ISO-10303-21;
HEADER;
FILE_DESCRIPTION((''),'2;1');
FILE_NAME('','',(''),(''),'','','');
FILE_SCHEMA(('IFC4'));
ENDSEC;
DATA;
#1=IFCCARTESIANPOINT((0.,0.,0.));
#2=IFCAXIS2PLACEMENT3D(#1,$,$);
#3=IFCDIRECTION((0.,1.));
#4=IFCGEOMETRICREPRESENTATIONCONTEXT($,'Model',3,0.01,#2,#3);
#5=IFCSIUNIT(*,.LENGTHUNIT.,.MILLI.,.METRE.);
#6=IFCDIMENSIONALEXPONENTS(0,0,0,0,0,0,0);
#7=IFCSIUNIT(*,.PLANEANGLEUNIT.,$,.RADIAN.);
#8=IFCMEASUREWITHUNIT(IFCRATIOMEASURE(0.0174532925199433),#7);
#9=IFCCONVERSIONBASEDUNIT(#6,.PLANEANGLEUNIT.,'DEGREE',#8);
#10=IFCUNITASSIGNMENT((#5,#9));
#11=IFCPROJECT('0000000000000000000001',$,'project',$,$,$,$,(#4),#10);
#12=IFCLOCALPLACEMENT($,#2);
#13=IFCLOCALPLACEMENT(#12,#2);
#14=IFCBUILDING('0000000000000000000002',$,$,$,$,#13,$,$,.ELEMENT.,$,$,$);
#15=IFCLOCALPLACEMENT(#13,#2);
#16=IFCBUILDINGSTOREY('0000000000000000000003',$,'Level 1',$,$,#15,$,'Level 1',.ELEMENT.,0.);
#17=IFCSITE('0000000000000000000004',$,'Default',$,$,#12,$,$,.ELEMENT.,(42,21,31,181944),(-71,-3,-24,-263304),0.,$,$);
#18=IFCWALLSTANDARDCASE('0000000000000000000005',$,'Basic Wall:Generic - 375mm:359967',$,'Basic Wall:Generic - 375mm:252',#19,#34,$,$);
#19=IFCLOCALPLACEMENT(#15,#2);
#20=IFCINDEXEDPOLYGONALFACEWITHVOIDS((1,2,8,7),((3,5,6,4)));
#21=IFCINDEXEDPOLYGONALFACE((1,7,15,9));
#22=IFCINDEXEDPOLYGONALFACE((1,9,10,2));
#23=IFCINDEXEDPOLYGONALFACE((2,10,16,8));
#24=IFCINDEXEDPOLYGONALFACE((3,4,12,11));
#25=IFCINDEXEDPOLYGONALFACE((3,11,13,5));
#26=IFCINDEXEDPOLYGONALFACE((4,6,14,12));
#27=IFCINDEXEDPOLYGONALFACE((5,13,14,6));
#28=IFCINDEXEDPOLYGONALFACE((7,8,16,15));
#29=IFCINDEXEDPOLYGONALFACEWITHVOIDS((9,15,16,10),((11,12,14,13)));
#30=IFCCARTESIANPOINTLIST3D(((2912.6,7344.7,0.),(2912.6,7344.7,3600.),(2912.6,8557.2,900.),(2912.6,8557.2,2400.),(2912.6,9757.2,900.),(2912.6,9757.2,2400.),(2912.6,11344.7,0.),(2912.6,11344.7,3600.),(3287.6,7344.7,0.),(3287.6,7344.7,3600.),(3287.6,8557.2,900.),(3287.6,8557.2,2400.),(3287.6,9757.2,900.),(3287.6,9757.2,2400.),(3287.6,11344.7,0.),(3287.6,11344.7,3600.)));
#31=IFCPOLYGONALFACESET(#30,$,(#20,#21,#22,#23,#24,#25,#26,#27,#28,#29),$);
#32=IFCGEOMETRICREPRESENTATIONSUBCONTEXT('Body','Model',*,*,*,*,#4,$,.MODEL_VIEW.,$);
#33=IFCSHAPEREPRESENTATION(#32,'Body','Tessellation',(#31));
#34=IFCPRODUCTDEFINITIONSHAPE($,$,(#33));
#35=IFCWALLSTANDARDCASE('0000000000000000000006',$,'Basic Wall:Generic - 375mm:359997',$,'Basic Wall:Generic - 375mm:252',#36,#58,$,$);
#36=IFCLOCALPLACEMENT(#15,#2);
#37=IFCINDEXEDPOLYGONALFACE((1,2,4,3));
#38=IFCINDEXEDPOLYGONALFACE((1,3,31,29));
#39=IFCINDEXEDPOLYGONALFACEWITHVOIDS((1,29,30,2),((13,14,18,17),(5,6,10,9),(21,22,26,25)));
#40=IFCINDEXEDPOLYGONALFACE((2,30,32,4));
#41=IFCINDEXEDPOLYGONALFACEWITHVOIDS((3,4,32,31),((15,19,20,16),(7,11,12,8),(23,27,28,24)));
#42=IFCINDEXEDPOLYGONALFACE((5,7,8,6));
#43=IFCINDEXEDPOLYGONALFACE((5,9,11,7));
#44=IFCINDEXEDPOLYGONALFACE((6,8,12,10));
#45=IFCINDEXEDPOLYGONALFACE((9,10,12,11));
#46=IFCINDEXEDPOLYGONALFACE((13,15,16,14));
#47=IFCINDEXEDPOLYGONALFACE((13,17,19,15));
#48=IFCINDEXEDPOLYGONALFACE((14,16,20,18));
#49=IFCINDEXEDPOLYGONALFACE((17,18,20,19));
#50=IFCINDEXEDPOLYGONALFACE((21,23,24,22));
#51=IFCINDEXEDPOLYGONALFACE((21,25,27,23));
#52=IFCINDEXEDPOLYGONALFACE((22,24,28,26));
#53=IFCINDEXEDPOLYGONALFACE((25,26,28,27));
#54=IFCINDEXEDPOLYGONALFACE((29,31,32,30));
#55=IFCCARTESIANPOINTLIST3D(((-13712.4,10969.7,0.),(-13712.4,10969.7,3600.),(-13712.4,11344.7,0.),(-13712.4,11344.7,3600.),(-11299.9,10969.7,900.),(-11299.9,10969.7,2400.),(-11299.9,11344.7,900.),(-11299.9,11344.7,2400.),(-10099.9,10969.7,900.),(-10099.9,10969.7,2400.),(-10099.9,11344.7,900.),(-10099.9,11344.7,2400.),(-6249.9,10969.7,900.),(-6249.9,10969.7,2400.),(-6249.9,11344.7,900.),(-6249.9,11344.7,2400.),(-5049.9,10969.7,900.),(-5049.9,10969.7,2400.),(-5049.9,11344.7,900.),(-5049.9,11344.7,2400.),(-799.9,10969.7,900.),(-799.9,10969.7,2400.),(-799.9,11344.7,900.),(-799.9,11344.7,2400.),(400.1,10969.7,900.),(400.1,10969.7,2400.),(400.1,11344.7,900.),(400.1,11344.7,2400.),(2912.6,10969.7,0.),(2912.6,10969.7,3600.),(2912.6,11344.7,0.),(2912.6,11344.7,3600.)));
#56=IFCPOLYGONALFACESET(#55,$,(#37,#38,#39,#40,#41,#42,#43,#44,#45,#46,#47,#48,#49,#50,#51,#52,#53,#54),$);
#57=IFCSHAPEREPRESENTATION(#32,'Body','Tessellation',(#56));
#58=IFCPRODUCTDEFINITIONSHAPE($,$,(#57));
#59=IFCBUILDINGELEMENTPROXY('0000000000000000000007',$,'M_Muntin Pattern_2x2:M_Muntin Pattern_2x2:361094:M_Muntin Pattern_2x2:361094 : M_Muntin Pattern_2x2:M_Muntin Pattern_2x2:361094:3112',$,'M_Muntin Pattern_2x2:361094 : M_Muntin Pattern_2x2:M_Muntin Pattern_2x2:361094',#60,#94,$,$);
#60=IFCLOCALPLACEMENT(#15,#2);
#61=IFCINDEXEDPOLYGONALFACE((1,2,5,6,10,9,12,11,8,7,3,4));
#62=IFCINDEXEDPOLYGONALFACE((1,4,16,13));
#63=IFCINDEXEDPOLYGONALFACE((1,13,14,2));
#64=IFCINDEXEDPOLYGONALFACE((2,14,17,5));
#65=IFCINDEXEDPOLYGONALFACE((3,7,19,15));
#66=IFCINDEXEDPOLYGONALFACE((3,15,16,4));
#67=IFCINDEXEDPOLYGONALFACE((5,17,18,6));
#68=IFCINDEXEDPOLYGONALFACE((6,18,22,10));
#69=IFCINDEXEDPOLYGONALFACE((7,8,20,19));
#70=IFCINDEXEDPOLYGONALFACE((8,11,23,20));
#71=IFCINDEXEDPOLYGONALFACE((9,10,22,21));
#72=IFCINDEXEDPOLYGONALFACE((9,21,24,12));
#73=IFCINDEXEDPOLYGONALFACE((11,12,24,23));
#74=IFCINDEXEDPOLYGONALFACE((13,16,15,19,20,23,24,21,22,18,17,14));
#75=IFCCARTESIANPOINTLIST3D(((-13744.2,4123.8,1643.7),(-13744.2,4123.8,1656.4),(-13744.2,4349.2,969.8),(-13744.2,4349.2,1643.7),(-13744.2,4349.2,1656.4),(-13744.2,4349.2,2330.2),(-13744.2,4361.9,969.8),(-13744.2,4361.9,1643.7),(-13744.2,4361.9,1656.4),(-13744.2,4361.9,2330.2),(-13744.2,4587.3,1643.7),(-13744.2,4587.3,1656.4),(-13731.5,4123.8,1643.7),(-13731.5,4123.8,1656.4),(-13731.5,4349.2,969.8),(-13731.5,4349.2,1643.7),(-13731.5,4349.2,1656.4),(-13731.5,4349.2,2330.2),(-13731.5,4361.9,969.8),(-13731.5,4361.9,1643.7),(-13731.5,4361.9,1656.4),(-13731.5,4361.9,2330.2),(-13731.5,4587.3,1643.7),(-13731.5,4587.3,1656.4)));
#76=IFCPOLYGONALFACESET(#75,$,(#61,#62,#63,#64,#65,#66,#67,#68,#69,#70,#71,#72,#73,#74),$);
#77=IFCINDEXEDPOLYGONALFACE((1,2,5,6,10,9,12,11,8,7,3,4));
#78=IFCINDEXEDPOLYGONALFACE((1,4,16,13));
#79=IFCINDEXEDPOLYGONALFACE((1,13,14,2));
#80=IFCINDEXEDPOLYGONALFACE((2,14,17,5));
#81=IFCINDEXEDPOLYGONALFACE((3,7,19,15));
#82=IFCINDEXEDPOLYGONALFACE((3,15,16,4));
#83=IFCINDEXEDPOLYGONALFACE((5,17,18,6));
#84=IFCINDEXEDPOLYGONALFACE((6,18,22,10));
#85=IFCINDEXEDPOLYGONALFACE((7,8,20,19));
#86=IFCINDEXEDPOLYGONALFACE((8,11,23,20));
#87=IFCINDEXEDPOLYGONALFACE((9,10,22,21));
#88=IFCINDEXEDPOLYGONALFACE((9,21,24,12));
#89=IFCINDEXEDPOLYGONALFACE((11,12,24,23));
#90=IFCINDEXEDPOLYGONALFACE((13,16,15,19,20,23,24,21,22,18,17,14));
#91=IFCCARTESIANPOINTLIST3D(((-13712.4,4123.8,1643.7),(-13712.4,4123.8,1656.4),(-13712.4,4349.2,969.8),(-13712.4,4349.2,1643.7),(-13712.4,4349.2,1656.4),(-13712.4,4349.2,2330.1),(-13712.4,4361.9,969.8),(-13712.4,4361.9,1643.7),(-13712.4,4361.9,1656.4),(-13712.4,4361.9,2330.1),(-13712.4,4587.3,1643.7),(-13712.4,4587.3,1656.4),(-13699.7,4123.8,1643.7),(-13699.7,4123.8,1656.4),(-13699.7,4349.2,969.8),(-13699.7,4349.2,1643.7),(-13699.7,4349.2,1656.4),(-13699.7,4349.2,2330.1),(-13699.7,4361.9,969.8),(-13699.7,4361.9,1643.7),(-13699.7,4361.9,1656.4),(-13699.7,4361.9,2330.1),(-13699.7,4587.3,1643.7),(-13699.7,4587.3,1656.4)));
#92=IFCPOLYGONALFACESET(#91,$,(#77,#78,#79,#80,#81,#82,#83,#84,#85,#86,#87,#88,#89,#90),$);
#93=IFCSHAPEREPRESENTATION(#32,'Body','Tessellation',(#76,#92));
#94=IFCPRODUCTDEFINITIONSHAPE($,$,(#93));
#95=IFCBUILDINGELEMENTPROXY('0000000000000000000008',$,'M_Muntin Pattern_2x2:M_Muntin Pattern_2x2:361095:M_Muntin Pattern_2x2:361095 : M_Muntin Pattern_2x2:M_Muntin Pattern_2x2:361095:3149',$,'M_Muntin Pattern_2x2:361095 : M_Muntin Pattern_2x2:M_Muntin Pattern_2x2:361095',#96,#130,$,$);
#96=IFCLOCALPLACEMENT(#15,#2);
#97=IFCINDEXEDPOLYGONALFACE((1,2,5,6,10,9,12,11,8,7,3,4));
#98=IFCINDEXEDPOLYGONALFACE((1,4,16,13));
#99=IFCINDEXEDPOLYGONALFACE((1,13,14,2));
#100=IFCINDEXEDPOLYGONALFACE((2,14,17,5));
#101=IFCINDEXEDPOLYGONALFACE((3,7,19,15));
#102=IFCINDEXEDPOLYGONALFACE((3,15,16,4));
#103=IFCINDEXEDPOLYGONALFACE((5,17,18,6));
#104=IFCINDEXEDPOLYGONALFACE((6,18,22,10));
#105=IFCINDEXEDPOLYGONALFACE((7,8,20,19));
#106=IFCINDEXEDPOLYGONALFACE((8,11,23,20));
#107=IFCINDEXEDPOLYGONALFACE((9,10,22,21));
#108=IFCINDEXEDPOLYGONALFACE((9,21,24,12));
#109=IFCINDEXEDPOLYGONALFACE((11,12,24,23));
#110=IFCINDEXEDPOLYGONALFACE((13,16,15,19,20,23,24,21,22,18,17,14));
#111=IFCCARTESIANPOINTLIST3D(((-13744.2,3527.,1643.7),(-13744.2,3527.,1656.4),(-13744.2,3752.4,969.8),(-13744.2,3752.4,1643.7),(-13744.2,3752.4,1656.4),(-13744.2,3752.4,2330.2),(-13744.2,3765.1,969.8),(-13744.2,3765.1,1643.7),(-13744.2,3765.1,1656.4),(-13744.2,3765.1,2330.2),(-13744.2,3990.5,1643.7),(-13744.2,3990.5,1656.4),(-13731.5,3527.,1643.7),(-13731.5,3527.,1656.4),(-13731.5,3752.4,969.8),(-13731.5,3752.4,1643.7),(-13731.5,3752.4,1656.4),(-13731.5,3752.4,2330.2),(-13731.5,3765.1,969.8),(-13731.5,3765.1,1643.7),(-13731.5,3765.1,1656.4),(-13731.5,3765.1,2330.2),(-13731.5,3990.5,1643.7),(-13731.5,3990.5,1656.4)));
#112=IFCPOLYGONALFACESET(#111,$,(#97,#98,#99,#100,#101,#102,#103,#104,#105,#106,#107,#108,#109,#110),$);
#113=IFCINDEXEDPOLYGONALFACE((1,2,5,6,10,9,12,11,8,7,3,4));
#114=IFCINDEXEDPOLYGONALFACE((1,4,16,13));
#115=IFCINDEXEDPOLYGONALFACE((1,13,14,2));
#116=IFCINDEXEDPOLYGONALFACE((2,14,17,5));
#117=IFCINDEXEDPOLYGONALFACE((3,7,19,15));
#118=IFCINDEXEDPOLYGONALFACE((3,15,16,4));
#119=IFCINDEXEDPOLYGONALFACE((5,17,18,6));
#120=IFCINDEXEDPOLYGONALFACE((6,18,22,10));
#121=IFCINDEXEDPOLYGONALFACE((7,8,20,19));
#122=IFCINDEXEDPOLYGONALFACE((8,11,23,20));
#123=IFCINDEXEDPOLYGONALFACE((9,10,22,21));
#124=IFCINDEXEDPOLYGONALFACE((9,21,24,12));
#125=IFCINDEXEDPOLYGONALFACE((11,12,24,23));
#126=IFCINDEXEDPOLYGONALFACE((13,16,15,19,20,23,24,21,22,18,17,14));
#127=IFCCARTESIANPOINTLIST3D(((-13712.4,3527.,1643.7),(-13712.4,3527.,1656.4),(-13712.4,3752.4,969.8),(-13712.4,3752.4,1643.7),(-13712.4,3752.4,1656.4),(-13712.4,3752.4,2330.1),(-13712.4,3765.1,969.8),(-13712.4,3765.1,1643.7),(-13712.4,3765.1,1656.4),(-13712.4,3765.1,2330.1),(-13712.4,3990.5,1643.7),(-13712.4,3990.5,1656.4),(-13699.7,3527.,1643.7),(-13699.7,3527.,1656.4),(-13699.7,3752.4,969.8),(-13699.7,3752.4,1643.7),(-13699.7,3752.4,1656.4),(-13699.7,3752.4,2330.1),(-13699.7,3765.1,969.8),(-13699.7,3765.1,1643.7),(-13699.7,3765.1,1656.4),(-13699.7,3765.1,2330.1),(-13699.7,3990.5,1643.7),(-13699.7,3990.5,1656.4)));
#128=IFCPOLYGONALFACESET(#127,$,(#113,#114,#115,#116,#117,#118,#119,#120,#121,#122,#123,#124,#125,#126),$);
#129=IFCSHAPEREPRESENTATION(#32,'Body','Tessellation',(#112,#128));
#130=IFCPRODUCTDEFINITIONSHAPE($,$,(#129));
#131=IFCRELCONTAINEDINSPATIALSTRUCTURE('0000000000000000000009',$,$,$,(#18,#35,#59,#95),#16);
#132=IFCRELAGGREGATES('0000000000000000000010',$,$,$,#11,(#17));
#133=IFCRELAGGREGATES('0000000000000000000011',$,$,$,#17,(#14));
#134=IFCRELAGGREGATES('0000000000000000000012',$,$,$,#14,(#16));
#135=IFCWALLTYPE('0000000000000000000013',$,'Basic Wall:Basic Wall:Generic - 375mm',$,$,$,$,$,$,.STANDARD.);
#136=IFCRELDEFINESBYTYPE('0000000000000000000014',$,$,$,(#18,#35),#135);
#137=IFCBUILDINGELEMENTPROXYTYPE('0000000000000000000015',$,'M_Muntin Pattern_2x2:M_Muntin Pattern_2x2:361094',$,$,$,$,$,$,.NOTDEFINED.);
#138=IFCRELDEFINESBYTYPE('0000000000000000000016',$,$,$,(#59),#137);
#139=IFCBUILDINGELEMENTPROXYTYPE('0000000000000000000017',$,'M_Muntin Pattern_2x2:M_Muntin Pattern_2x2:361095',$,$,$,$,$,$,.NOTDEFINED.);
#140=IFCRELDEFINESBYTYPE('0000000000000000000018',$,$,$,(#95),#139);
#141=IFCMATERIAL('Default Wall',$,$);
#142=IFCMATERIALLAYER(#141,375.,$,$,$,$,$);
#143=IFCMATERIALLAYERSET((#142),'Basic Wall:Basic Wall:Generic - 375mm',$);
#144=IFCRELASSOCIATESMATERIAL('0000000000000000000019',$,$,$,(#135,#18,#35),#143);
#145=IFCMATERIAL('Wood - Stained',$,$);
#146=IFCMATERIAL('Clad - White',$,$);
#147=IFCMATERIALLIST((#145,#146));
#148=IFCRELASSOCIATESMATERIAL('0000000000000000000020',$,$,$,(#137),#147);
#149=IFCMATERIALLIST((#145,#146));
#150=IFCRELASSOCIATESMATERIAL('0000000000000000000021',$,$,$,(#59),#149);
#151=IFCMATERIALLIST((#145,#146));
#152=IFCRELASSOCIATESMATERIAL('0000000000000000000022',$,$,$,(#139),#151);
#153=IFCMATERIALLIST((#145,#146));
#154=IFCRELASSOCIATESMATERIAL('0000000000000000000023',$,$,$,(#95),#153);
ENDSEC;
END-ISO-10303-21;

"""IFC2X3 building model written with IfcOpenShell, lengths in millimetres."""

from ifc_helpers import new_model, entity, si_unit, converted_unit, direction, frame, frame_2d, origin, place, context, subcontext, project, spatial, polyline, rectangle, outline, extrude, source, transform, mapped, material, material_list, layer, layer_set, layer_usage, type_object, type_shapes, element, save


model = new_model("IFC2X3")

# Units and contexts
model_context = context("Model", 3, precision=0.01, world=origin(), true_north=direction((0.0, 1.0)))
body_context = subcontext(model_context, "Body", "Model", "MODEL_VIEW")
ifc_project = project(units=[si_unit("LENGTHUNIT", "METRE", prefix="MILLI"), converted_unit("PLANEANGLEUNIT", "DEGREE", entity("IfcRatioMeasure", 0.0174532925199433), si_unit("PLANEANGLEUNIT", "RADIAN"), dimensions=[0, 0, 0, 0, 0, 0, 0])], contexts=[model_context])

# Site, building, storey
site_placement = place(None, origin())
site = spatial("IfcSite", under=ifc_project, at=site_placement, Name="Default", CompositionType="ELEMENT", RefLatitude=(42, 21, 31, 181944), RefLongitude=(-71, -3, -24, -263304), RefElevation=0.0)
building_placement = place(site_placement, origin())
building = spatial("IfcBuilding", under=site, at=building_placement, CompositionType="ELEMENT")
storey_placement = place(building_placement, origin())
storey = spatial("IfcBuildingStorey", under=building, at=storey_placement, Name="Level 1", LongName="Level 1", CompositionType="ELEMENT", Elevation=0.0)

# Wall, opening
ifc_material_1 = material(Name="Default Wall")
ifc_layer = layer(ifc_material_1, 375.0)
ifc_layer_set = layer_set([ifc_layer], Name="Basic Wall:Basic Wall:Generic - 375mm")
ifc_layer_usage_1 = layer_usage(ifc_layer_set, "AXIS2", "NEGATIVE", 187.5)
wall_type = type_object("IfcWallType", Name="Basic Wall:Basic Wall:Generic - 375mm", PredefinedType="STANDARD", material=ifc_layer_set)
wall_1_placement = place(storey_placement, frame((3100.1, 7344.7, 0.0), z_axis=(0.0, 0.0, 1.0), x_axis=(0.0, 1.0, 0.0)))
wall_1 = element("IfcWallStandardCase", 1, at=wall_1_placement, inside=storey, type_object=wall_type, material=ifc_layer_usage_1, Name="Basic Wall:Generic - 375mm:359967", ObjectType="Basic Wall:Generic - 375mm:252", context=body_context, shape_type="SweptSolid", body=[
    extrude(rectangle(XDim=4000.0, YDim=375.0, at=frame_2d((2000.0, 0.0), x_axis=(-1.0, 0.0))), origin(), (0.0, 0.0, 1.0), 3600.0),
])
opening_1_placement = place(wall_1_placement, frame((-7344.7, 3100.1, 0.0), z_axis=(0.0, 0.0, 1.0), x_axis=(0.0, -1.0, 0.0)))
element("IfcOpeningElement", 2, at=opening_1_placement, cuts=wall_1, ObjectType="Opening", context=body_context, shape_type="SweptSolid", body=[
    extrude(rectangle(XDim=1500.0, YDim=1200.0, at=frame_2d((0.0, 0.0), x_axis=(0.0, 1.0))), frame((3291.3, 9157.2, 1650.0), z_axis=(-1.0, 0.0, 0.0), x_axis=(0.0, -1.0, 0.0)), (0.0, 0.0, 1.0), 382.5),
])

# Wall, openings
ifc_layer_usage_2 = layer_usage(ifc_layer_set, "AXIS2", "NEGATIVE", 187.5)
wall_2_placement = place(storey_placement, frame((2912.6, 11157.2, 0.0), z_axis=(0.0, 0.0, 1.0), x_axis=(-1.0, 0.0, 0.0)))
wall_2 = element("IfcWallStandardCase", 3, at=wall_2_placement, inside=storey, type_object=wall_type, material=ifc_layer_usage_2, Name="Basic Wall:Generic - 375mm:359997", ObjectType="Basic Wall:Generic - 375mm:252", context=body_context, shape_type="SweptSolid", body=[
    extrude(rectangle(XDim=16625.0, YDim=375.0, at=frame_2d((8312.5, 0.0), x_axis=(-1.0, 0.0))), origin(), (0.0, 0.0, 1.0), 3600.0),
])
opening_2_placement = place(wall_2_placement, frame((2912.6, 11157.2, 0.0), z_axis=(0.0, 0.0, 1.0), x_axis=(-1.0, 0.0, 0.0)))
element("IfcOpeningElement", 4, at=opening_2_placement, cuts=wall_2, ObjectType="Opening", context=body_context, shape_type="SweptSolid", body=[
    extrude(rectangle(XDim=1500.0, YDim=1200.0, at=frame_2d((0.0, 0.0), x_axis=(0.0, 1.0))), frame((-5649.9, 11348.4, 1650.0), z_axis=(0.0, -1.0, 0.0), x_axis=(1.0, 0.0, 0.0)), (0.0, 0.0, 1.0), 382.5),
])
opening_3_placement = place(wall_2_placement, frame((2912.6, 11157.2, 0.0), z_axis=(0.0, 0.0, 1.0), x_axis=(-1.0, 0.0, 0.0)))
element("IfcOpeningElement", 5, at=opening_3_placement, cuts=wall_2, ObjectType="Opening", context=body_context, shape_type="SweptSolid", body=[
    extrude(rectangle(XDim=1500.0, YDim=1200.0, at=frame_2d((0.0, 0.0), x_axis=(0.0, 1.0))), frame((-199.9, 11348.4, 1650.0), z_axis=(0.0, -1.0, 0.0), x_axis=(1.0, 0.0, 0.0)), (0.0, 0.0, 1.0), 382.5),
])
opening_4_placement = place(wall_2_placement, frame((2912.6, 11157.2, 0.0), z_axis=(0.0, 0.0, 1.0), x_axis=(-1.0, 0.0, 0.0)))
element("IfcOpeningElement", 6, at=opening_4_placement, cuts=wall_2, ObjectType="Opening", context=body_context, shape_type="SweptSolid", body=[
    extrude(rectangle(XDim=1500.0, YDim=1200.0, at=frame_2d((0.0, 0.0), x_axis=(0.0, 1.0))), frame((-10699.9, 11348.4, 1650.0), z_axis=(0.0, -1.0, 0.0), x_axis=(1.0, 0.0, 0.0)), (0.0, 0.0, 1.0), 382.5),
])

# Building element proxies
ifc_material_2 = material(Name="Wood - Stained")
ifc_material_3 = material(Name="Clad - White")
ifc_material_list_1 = material_list([ifc_material_2, ifc_material_3])
ifc_material_list_2 = material_list([ifc_material_2, ifc_material_3])
building_element_proxy_type_1 = type_object("IfcBuildingElementProxyType", Name="M_Muntin Pattern_2x2:M_Muntin Pattern_2x2:361094", PredefinedType="NOTDEFINED", material=ifc_material_list_2)
shared_shape_1 = source(origin(), body_context, "Body", "SweptSolid", [
    extrude(outline(polyline([(-6.4, -680.2), (6.3, -680.2), (6.3, -6.4), (231.7, -6.4), (231.7, 6.3), (6.3, 6.3), (6.3, 680.2), (-6.4, 680.2), (-6.4, 6.3), (-231.7, 6.3), (-231.7, -6.4), (-6.4, -6.4), (-6.4, -680.2)])), frame((-13744.2, 4355.6, 1650.0), z_axis=(1.0, 0.0, 0.0), x_axis=(0.0, -1.0, 0.0)), (0.0, 0.0, 1.0), 12.7),
    extrude(outline(polyline([(-6.4, -680.1), (6.3, -680.1), (6.3, -6.4), (231.7, -6.4), (231.7, 6.3), (6.3, 6.3), (6.3, 680.2), (-6.4, 680.2), (-6.4, 6.3), (-231.7, 6.3), (-231.7, -6.4), (-6.4, -6.4), (-6.4, -680.1)])), frame((-13712.4, 4355.6, 1650.0), z_axis=(1.0, 0.0, 0.0), x_axis=(0.0, -1.0, 0.0)), (0.0, 0.0, 1.0), 12.7),
])
type_shapes(building_element_proxy_type_1, [shared_shape_1])
proxy_1_placement = place(storey_placement, origin())
element("IfcBuildingElementProxy", 7, at=proxy_1_placement, inside=storey, type_object=building_element_proxy_type_1, material=ifc_material_list_1, Name="M_Muntin Pattern_2x2:M_Muntin Pattern_2x2:361094:M_Muntin Pattern_2x2:361094 : M_Muntin Pattern_2x2:M_Muntin Pattern_2x2:361094:3112", ObjectType="M_Muntin Pattern_2x2:361094 : M_Muntin Pattern_2x2:M_Muntin Pattern_2x2:361094", context=body_context, shape_type="MappedRepresentation", body=[
    mapped(shared_shape_1, transform((0.0, 0.0, 0.0), scale=1.0)),
])
ifc_material_list_3 = material_list([ifc_material_2, ifc_material_3])
ifc_material_list_4 = material_list([ifc_material_2, ifc_material_3])
building_element_proxy_type_2 = type_object("IfcBuildingElementProxyType", Name="M_Muntin Pattern_2x2:M_Muntin Pattern_2x2:361095", PredefinedType="NOTDEFINED", material=ifc_material_list_4)
shared_shape_2 = source(origin(), body_context, "Body", "SweptSolid", [
    extrude(outline(polyline([(-680.1, 6.4), (-680.1, -6.3), (-6.4, -6.3), (-6.4, -231.7), (6.3, -231.7), (6.3, -6.3), (680.2, -6.3), (680.2, 6.4), (6.3, 6.4), (6.3, 231.7), (-6.4, 231.7), (-6.4, 6.4), (-680.1, 6.4)])), frame((-13744.2, 3758.7, 1650.0), z_axis=(-1.0, 0.0, 0.0), x_axis=(0.0, 0.0, -1.0)), (0.0, 0.0, -1.0), 12.7),
    extrude(outline(polyline([(-680.1, 6.4), (-680.1, -6.3), (-6.4, -6.3), (-6.4, -231.7), (6.3, -231.7), (6.3, -6.3), (680.2, -6.3), (680.2, 6.4), (6.3, 6.4), (6.3, 231.7), (-6.4, 231.7), (-6.4, 6.4), (-680.1, 6.4)])), frame((-13712.4, 3758.7, 1650.0), z_axis=(-1.0, 0.0, 0.0), x_axis=(0.0, 0.0, -1.0)), (0.0, 0.0, -1.0), 12.7),
])
type_shapes(building_element_proxy_type_2, [shared_shape_2])
proxy_2_placement = place(storey_placement, origin())
element("IfcBuildingElementProxy", 8, at=proxy_2_placement, inside=storey, type_object=building_element_proxy_type_2, material=ifc_material_list_3, Name="M_Muntin Pattern_2x2:M_Muntin Pattern_2x2:361095:M_Muntin Pattern_2x2:361095 : M_Muntin Pattern_2x2:M_Muntin Pattern_2x2:361095:3149", ObjectType="M_Muntin Pattern_2x2:361095 : M_Muntin Pattern_2x2:M_Muntin Pattern_2x2:361095", context=body_context, shape_type="MappedRepresentation", body=[
    mapped(shared_shape_2, transform((0.0, 0.0, 0.0), scale=1.0)),
])

save(model, "model.ifc")
